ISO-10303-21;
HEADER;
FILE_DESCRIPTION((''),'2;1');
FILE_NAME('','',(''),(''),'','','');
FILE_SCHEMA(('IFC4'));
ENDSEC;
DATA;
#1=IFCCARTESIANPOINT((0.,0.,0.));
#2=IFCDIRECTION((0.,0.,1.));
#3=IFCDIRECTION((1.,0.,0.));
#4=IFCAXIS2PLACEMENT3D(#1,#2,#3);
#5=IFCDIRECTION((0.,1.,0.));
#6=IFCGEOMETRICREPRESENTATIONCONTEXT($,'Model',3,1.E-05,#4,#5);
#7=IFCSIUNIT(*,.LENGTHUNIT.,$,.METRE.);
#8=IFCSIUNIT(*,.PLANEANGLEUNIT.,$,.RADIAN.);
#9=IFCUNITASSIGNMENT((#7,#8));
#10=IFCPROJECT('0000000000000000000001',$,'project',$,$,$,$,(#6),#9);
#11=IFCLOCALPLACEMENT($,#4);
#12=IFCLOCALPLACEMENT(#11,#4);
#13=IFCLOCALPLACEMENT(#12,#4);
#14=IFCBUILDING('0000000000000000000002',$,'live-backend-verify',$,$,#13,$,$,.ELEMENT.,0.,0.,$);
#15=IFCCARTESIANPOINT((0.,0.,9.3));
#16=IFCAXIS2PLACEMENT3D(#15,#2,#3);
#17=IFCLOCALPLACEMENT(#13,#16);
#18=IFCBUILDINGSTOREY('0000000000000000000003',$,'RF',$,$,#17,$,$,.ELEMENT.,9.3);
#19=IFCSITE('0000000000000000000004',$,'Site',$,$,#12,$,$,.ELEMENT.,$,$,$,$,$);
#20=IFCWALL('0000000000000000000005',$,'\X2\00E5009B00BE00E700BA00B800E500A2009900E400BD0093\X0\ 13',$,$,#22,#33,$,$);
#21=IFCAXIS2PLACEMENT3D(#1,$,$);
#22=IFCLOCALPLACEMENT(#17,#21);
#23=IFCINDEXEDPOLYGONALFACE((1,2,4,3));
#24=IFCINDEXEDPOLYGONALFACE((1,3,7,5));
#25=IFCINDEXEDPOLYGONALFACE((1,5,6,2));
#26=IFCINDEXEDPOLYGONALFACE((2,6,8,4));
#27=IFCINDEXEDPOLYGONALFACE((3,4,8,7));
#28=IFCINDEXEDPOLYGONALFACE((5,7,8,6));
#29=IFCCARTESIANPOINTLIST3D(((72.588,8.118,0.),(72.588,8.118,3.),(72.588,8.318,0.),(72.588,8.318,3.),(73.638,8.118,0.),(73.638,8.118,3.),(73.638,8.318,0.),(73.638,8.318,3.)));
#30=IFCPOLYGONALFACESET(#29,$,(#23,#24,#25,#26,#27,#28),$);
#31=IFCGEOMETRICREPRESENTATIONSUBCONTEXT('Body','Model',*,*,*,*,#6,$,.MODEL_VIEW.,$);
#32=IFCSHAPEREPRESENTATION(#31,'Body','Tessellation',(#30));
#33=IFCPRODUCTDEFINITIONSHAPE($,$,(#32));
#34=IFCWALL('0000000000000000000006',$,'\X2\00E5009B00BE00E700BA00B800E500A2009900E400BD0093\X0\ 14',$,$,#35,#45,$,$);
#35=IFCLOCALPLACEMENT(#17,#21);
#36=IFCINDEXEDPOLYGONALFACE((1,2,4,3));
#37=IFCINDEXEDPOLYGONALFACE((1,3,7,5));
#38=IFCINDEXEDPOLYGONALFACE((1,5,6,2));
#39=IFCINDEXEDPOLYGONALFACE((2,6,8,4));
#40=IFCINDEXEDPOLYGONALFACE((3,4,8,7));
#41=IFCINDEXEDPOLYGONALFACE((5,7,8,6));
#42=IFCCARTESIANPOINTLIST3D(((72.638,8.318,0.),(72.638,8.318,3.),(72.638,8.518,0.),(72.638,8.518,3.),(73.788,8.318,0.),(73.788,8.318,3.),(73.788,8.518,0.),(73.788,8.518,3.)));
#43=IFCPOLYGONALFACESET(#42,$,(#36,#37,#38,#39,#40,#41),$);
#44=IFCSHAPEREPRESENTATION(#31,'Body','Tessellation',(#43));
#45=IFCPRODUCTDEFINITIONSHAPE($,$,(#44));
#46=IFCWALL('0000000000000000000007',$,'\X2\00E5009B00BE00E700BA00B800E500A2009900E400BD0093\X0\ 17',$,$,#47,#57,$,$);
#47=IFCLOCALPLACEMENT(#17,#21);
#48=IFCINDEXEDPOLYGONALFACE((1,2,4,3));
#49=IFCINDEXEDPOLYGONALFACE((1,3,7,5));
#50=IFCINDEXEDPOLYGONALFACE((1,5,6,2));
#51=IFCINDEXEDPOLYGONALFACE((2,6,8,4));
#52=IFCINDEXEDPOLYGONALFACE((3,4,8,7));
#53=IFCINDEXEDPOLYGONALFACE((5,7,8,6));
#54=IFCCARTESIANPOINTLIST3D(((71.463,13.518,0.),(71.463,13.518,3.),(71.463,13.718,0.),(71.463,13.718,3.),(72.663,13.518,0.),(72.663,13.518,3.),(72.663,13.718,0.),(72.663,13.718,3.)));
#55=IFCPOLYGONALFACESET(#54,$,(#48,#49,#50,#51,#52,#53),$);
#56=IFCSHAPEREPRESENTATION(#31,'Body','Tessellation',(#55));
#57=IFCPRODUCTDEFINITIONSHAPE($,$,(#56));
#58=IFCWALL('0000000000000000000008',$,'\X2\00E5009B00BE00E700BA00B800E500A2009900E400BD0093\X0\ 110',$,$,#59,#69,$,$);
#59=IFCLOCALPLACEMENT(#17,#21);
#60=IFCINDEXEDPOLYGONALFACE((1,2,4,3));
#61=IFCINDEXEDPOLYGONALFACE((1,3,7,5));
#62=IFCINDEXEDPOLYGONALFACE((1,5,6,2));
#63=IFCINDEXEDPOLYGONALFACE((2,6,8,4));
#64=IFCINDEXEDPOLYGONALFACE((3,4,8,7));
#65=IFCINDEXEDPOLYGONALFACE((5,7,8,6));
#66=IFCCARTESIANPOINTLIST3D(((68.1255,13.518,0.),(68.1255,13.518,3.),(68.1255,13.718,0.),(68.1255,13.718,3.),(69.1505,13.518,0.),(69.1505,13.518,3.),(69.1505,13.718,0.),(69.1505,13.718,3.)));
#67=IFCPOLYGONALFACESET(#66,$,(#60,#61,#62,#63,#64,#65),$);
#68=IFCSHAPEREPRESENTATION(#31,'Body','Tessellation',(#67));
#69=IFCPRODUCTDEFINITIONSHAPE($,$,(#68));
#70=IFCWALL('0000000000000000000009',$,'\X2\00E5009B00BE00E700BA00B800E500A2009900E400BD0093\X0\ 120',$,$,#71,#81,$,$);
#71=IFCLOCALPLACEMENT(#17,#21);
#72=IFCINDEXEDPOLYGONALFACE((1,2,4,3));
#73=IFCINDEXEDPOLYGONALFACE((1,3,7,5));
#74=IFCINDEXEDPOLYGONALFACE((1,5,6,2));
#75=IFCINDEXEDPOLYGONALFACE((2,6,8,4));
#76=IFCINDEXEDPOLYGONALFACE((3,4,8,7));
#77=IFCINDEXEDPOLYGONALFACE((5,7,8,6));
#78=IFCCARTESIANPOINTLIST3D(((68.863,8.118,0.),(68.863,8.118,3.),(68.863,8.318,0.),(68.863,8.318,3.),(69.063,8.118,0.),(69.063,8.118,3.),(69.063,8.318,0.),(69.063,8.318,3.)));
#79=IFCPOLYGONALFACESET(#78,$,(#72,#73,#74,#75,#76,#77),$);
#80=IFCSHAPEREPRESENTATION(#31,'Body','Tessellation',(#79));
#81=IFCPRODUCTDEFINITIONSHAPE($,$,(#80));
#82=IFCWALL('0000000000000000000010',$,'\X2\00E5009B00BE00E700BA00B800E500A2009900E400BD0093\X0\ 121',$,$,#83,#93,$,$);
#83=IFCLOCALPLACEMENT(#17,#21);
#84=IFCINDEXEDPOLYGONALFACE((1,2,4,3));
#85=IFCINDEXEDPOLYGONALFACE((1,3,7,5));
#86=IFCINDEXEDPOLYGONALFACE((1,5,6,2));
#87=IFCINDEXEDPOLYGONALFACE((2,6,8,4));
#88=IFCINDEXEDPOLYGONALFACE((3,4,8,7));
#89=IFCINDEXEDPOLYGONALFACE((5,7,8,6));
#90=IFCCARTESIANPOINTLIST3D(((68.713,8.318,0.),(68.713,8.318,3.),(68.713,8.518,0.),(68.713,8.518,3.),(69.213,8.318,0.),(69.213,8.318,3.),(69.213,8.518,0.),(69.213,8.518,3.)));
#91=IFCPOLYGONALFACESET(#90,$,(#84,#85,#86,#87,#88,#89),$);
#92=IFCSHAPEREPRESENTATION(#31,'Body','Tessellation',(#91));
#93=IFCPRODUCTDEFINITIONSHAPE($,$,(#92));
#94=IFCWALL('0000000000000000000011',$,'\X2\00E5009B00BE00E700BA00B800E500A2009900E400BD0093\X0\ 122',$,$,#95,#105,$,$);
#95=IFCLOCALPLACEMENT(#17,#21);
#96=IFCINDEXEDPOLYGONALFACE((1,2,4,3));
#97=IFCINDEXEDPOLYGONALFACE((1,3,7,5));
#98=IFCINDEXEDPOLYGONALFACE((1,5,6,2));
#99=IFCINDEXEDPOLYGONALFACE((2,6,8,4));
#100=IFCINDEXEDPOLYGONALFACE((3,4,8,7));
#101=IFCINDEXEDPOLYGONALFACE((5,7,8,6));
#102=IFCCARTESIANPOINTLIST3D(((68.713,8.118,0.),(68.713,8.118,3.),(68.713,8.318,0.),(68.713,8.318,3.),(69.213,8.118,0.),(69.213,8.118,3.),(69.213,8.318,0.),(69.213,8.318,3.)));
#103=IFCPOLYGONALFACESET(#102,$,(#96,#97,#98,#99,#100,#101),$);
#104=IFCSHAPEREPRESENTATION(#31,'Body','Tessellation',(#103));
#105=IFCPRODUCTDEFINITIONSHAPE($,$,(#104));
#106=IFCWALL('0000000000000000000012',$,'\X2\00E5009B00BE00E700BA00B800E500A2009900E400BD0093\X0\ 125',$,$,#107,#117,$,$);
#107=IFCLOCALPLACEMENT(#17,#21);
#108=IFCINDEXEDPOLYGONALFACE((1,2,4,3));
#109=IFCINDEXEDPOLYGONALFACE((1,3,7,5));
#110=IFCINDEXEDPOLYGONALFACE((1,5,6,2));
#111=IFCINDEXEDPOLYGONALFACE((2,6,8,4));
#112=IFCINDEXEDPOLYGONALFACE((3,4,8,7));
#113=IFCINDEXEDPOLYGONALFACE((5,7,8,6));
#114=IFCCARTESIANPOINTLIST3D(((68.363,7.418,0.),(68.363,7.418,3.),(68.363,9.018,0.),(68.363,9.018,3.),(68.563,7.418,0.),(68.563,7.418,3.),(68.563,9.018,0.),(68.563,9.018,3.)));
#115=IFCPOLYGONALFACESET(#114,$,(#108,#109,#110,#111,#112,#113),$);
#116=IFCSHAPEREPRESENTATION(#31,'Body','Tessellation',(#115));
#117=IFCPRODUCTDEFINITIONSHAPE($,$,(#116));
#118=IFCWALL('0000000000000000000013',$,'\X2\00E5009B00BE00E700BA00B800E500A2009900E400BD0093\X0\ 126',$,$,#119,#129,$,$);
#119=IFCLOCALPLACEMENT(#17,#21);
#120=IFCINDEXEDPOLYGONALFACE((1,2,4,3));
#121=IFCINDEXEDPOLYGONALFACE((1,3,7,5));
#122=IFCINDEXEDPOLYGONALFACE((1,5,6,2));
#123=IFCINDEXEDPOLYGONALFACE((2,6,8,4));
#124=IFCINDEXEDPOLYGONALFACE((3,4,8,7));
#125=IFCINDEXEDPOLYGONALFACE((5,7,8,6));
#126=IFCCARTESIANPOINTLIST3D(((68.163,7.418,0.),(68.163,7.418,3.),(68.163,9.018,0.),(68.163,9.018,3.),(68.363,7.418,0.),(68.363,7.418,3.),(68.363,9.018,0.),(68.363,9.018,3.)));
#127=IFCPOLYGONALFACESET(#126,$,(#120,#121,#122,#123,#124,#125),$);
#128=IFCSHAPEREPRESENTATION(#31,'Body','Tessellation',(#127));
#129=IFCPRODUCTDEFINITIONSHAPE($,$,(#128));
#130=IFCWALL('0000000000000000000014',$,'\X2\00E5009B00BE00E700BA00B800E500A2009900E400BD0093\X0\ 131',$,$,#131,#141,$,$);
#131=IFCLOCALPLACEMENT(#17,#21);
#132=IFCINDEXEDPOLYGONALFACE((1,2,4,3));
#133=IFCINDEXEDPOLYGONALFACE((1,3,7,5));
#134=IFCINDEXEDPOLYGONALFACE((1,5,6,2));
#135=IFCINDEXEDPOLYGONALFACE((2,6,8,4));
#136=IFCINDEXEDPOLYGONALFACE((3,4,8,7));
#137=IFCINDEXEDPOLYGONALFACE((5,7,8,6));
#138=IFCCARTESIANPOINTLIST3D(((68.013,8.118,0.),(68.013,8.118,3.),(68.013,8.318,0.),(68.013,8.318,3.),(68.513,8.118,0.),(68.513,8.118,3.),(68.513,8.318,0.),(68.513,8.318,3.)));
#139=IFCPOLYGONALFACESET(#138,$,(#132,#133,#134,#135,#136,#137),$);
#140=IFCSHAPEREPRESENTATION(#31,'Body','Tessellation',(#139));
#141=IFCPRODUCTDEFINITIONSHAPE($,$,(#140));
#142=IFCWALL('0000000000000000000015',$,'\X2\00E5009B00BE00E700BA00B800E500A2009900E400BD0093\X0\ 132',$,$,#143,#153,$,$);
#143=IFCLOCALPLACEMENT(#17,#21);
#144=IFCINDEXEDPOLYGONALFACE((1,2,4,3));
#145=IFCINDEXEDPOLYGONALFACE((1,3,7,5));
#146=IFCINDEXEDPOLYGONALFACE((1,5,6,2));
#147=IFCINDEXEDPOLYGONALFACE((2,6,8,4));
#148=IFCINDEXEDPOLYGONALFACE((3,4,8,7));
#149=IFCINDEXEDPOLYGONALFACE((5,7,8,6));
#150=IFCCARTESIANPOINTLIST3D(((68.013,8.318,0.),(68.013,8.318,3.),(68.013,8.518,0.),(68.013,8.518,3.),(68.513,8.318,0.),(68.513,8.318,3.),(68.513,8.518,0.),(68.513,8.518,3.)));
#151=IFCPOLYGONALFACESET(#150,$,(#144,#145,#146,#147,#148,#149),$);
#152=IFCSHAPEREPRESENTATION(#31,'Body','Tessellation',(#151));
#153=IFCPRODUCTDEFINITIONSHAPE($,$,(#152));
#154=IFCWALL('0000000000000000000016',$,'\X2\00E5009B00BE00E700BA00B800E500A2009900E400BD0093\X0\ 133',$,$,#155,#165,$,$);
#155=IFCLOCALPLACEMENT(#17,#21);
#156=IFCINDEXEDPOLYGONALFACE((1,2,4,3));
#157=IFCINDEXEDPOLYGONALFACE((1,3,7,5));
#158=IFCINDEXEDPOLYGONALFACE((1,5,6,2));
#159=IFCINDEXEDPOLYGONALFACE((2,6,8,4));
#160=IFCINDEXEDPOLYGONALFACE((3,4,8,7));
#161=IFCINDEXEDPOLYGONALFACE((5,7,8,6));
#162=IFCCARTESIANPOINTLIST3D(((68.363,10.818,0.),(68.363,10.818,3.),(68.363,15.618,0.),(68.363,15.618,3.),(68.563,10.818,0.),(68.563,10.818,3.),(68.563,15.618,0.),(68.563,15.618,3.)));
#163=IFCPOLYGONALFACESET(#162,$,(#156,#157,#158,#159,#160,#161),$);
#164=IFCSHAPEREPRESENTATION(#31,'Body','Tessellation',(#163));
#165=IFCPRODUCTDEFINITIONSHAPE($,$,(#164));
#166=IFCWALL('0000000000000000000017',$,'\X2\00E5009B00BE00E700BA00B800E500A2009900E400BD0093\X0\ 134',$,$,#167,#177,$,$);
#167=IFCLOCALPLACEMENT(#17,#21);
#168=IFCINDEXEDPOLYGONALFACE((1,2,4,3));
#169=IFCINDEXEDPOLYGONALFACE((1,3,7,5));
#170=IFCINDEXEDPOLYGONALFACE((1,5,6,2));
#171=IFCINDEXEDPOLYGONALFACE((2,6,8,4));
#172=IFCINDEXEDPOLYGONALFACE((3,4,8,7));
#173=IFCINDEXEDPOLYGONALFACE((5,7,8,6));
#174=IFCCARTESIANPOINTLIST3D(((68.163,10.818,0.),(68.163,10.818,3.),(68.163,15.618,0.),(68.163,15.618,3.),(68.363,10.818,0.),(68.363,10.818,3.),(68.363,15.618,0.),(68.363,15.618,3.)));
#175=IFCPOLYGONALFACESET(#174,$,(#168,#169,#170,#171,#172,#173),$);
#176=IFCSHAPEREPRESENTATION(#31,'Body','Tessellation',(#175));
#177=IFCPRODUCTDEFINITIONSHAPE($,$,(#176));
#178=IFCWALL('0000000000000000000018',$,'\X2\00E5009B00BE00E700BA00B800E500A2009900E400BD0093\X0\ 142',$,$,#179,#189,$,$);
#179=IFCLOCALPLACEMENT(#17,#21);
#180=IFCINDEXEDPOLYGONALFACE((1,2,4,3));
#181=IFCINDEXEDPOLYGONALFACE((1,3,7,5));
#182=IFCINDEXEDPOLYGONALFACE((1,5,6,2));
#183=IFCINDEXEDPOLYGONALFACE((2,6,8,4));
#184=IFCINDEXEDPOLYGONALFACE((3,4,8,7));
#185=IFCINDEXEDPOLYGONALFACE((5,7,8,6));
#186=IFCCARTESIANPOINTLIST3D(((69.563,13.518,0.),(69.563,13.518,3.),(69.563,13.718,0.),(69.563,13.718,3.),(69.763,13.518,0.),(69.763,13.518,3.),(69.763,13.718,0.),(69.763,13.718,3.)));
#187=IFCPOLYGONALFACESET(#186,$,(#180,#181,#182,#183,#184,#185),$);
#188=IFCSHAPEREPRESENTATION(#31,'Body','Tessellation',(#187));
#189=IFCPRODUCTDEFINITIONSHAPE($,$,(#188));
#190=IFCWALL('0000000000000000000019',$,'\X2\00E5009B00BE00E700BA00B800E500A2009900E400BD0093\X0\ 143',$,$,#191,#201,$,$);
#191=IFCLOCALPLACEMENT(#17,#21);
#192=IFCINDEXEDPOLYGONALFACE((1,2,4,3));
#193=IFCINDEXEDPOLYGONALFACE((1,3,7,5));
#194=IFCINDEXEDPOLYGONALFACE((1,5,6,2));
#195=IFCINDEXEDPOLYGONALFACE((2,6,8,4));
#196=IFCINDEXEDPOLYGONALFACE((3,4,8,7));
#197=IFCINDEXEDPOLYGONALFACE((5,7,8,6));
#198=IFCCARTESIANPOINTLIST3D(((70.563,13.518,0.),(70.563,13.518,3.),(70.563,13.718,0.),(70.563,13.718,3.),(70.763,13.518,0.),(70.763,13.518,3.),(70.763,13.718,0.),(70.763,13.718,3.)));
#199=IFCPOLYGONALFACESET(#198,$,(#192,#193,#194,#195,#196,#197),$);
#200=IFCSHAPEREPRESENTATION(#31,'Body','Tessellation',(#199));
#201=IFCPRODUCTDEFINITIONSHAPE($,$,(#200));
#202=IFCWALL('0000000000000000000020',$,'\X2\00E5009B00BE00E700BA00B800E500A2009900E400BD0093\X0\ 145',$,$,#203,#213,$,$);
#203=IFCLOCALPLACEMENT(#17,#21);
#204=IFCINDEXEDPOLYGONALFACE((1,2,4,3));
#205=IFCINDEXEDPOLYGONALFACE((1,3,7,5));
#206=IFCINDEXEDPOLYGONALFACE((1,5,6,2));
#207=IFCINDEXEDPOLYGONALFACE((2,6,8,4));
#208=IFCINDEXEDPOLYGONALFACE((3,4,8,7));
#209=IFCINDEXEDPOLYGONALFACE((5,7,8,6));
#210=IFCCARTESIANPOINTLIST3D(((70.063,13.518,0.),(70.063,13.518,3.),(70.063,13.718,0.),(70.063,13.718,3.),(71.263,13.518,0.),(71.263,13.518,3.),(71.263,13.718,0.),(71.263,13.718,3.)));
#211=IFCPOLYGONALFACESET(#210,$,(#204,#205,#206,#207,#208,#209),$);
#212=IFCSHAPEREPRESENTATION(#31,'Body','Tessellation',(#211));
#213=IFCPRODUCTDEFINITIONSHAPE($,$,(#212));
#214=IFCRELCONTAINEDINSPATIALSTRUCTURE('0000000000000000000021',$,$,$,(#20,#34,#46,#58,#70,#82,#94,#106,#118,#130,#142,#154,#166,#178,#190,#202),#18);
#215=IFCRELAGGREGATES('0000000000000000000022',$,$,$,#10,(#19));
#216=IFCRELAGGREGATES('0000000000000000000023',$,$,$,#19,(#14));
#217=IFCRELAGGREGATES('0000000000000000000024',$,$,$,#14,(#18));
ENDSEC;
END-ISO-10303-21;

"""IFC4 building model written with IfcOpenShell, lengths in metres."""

from ifc_helpers import new_model, si_unit, direction, frame, frame_2d, origin_with_axes, place, context, subcontext, project, spatial, rectangle, extrude, element, save


model = new_model("IFC4")

# Units and contexts
model_context = context("Model", 3, precision=1e-05, world=origin_with_axes(), true_north=direction((0.0, 1.0, 0.0)))
body_context = subcontext(model_context, "Body", "Model", "MODEL_VIEW")
ifc_project = project(units=[si_unit("LENGTHUNIT", "METRE"), si_unit("PLANEANGLEUNIT", "RADIAN")], contexts=[model_context])

# Site, building, storey
placement = place(None, origin_with_axes())
site_placement = place(placement, origin_with_axes())
site = spatial("IfcSite", under=ifc_project, at=site_placement, Name="Site", CompositionType="ELEMENT")
building_placement = place(site_placement, origin_with_axes())
building = spatial("IfcBuilding", under=site, at=building_placement, Name="live-backend-verify", CompositionType="ELEMENT", ElevationOfRefHeight=0.0, ElevationOfTerrain=0.0)
storey_placement = place(building_placement, frame((0.0, 0.0, 9.3), z_axis=(0.0, 0.0, 1.0), x_axis=(1.0, 0.0, 0.0)))
storey = spatial("IfcBuildingStorey", under=building, at=storey_placement, Name="RF", CompositionType="ELEMENT", Elevation=9.3)

# Walls
wall_1_placement = place(storey_placement, frame((73.113, 8.218, 0.0), z_axis=(0.0, 0.0, 1.0), x_axis=(-1.0, 0.0, 0.0)))
element("IfcWall", 1, at=wall_1_placement, inside=storey, Name="å\u009b¾çº¸å¢\u0099ä½\u0093 13", context=body_context, shape_type="SweptSolid", body=[
    extrude(rectangle(XDim=1.05, YDim=0.2, at=frame_2d((0.0, 0.0), x_axis=(1.0, 0.0, 0.0))), frame((0.0, 0.0, 0.0), z_axis=(0.0, 0.0, 1.0)), (0.0, 0.0, 1.0), 3.0),
])
wall_2_placement = place(storey_placement, frame((73.213, 8.418, 0.0), z_axis=(0.0, 0.0, 1.0), x_axis=(-1.0, 0.0, 0.0)))
element("IfcWall", 2, at=wall_2_placement, inside=storey, Name="å\u009b¾çº¸å¢\u0099ä½\u0093 14", context=body_context, shape_type="SweptSolid", body=[
    extrude(rectangle(XDim=1.15, YDim=0.2, at=frame_2d((0.0, 0.0), x_axis=(1.0, 0.0, 0.0))), frame((0.0, 0.0, 0.0), z_axis=(0.0, 0.0, 1.0)), (0.0, 0.0, 1.0), 3.0),
])
wall_3_placement = place(storey_placement, frame((72.063, 13.618, 0.0), z_axis=(0.0, 0.0, 1.0), x_axis=(1.0, 0.0, 0.0)))
element("IfcWall", 3, at=wall_3_placement, inside=storey, Name="å\u009b¾çº¸å¢\u0099ä½\u0093 17", context=body_context, shape_type="SweptSolid", body=[
    extrude(rectangle(XDim=1.2, YDim=0.2, at=frame_2d((0.0, 0.0), x_axis=(1.0, 0.0, 0.0))), frame((0.0, 0.0, 0.0), z_axis=(0.0, 0.0, 1.0)), (0.0, 0.0, 1.0), 3.0),
])
wall_4_placement = place(storey_placement, frame((68.638, 13.618, 0.0), z_axis=(0.0, 0.0, 1.0), x_axis=(1.0, 0.0, 0.0)))
element("IfcWall", 4, at=wall_4_placement, inside=storey, Name="å\u009b¾çº¸å¢\u0099ä½\u0093 110", context=body_context, shape_type="SweptSolid", body=[
    extrude(rectangle(XDim=1.025, YDim=0.2, at=frame_2d((0.0, 0.0), x_axis=(1.0, 0.0, 0.0))), frame((0.0, 0.0, 0.0), z_axis=(0.0, 0.0, 1.0)), (0.0, 0.0, 1.0), 3.0),
])
wall_5_placement = place(storey_placement, frame((68.963, 8.218, 0.0), z_axis=(0.0, 0.0, 1.0), x_axis=(0.0, 1.0, 0.0)))
element("IfcWall", 5, at=wall_5_placement, inside=storey, Name="å\u009b¾çº¸å¢\u0099ä½\u0093 120", context=body_context, shape_type="SweptSolid", body=[
    extrude(rectangle(XDim=0.2, YDim=0.2, at=frame_2d((0.0, 0.0), x_axis=(1.0, 0.0, 0.0))), frame((0.0, 0.0, 0.0), z_axis=(0.0, 0.0, 1.0)), (0.0, 0.0, 1.0), 3.0),
])
for number, where, z_axis, x_axis, name in (
    (6, (68.963, 8.418, 0.0), (0.0, 0.0, 1.0), (-1.0, 0.0, 0.0), "å\u009b¾çº¸å¢\u0099ä½\u0093 121"),
    (7, (68.963, 8.218, 0.0), (0.0, 0.0, 1.0), (-1.0, 0.0, 0.0), "å\u009b¾çº¸å¢\u0099ä½\u0093 122"),
):
    element("IfcWall", number, at=place(storey_placement, frame(where, z_axis=z_axis, x_axis=x_axis)), inside=storey, Name=name, context=body_context, shape_type="SweptSolid", body=[
        extrude(rectangle(XDim=0.5, YDim=0.2, at=frame_2d((0.0, 0.0), x_axis=(1.0, 0.0, 0.0))), frame((0.0, 0.0, 0.0), z_axis=(0.0, 0.0, 1.0)), (0.0, 0.0, 1.0), 3.0),
    ])
for number, where, z_axis, x_axis, name in (
    (8, (68.463, 8.218, 0.0), (0.0, 0.0, 1.0), (0.0, -1.0, 0.0), "å\u009b¾çº¸å¢\u0099ä½\u0093 125"),
    (9, (68.263, 8.218, 0.0), (0.0, 0.0, 1.0), (0.0, -1.0, 0.0), "å\u009b¾çº¸å¢\u0099ä½\u0093 126"),
):
    element("IfcWall", number, at=place(storey_placement, frame(where, z_axis=z_axis, x_axis=x_axis)), inside=storey, Name=name, context=body_context, shape_type="SweptSolid", body=[
        extrude(rectangle(XDim=1.6, YDim=0.2, at=frame_2d((0.0, 0.0), x_axis=(1.0, 0.0, 0.0))), frame((0.0, 0.0, 0.0), z_axis=(0.0, 0.0, 1.0)), (0.0, 0.0, 1.0), 3.0),
    ])
for number, where, z_axis, x_axis, name in (
    (10, (68.263, 8.218, 0.0), (0.0, 0.0, 1.0), (-1.0, 0.0, 0.0), "å\u009b¾çº¸å¢\u0099ä½\u0093 131"),
    (11, (68.263, 8.418, 0.0), (0.0, 0.0, 1.0), (-1.0, 0.0, 0.0), "å\u009b¾çº¸å¢\u0099ä½\u0093 132"),
):
    element("IfcWall", number, at=place(storey_placement, frame(where, z_axis=z_axis, x_axis=x_axis)), inside=storey, Name=name, context=body_context, shape_type="SweptSolid", body=[
        extrude(rectangle(XDim=0.5, YDim=0.2, at=frame_2d((0.0, 0.0), x_axis=(1.0, 0.0, 0.0))), frame((0.0, 0.0, 0.0), z_axis=(0.0, 0.0, 1.0)), (0.0, 0.0, 1.0), 3.0),
    ])
for number, where, z_axis, x_axis, name in (
    (12, (68.463, 13.218, 0.0), (0.0, 0.0, 1.0), (0.0, -1.0, 0.0), "å\u009b¾çº¸å¢\u0099ä½\u0093 133"),
    (13, (68.263, 13.218, 0.0), (0.0, 0.0, 1.0), (0.0, -1.0, 0.0), "å\u009b¾çº¸å¢\u0099ä½\u0093 134"),
):
    element("IfcWall", number, at=place(storey_placement, frame(where, z_axis=z_axis, x_axis=x_axis)), inside=storey, Name=name, context=body_context, shape_type="SweptSolid", body=[
        extrude(rectangle(XDim=4.8, YDim=0.2, at=frame_2d((0.0, 0.0), x_axis=(1.0, 0.0, 0.0))), frame((0.0, 0.0, 0.0), z_axis=(0.0, 0.0, 1.0)), (0.0, 0.0, 1.0), 3.0),
    ])
for number, where, z_axis, x_axis, name in (
    (14, (69.663, 13.618, 0.0), (0.0, 0.0, 1.0), (0.0, 1.0, 0.0), "å\u009b¾çº¸å¢\u0099ä½\u0093 142"),
    (15, (70.663, 13.618, 0.0), (0.0, 0.0, 1.0), (0.0, 1.0, 0.0), "å\u009b¾çº¸å¢\u0099ä½\u0093 143"),
):
    element("IfcWall", number, at=place(storey_placement, frame(where, z_axis=z_axis, x_axis=x_axis)), inside=storey, Name=name, context=body_context, shape_type="SweptSolid", body=[
        extrude(rectangle(XDim=0.2, YDim=0.2, at=frame_2d((0.0, 0.0), x_axis=(1.0, 0.0, 0.0))), frame((0.0, 0.0, 0.0), z_axis=(0.0, 0.0, 1.0)), (0.0, 0.0, 1.0), 3.0),
    ])
wall_6_placement = place(storey_placement, frame((70.663, 13.618, 0.0), z_axis=(0.0, 0.0, 1.0), x_axis=(1.0, 0.0, 0.0)))
element("IfcWall", 16, at=wall_6_placement, inside=storey, Name="å\u009b¾çº¸å¢\u0099ä½\u0093 145", context=body_context, shape_type="SweptSolid", body=[
    extrude(rectangle(XDim=1.2, YDim=0.2, at=frame_2d((0.0, 0.0), x_axis=(1.0, 0.0, 0.0))), frame((0.0, 0.0, 0.0), z_axis=(0.0, 0.0, 1.0)), (0.0, 0.0, 1.0), 3.0),
])

save(model, "model.ifc")
